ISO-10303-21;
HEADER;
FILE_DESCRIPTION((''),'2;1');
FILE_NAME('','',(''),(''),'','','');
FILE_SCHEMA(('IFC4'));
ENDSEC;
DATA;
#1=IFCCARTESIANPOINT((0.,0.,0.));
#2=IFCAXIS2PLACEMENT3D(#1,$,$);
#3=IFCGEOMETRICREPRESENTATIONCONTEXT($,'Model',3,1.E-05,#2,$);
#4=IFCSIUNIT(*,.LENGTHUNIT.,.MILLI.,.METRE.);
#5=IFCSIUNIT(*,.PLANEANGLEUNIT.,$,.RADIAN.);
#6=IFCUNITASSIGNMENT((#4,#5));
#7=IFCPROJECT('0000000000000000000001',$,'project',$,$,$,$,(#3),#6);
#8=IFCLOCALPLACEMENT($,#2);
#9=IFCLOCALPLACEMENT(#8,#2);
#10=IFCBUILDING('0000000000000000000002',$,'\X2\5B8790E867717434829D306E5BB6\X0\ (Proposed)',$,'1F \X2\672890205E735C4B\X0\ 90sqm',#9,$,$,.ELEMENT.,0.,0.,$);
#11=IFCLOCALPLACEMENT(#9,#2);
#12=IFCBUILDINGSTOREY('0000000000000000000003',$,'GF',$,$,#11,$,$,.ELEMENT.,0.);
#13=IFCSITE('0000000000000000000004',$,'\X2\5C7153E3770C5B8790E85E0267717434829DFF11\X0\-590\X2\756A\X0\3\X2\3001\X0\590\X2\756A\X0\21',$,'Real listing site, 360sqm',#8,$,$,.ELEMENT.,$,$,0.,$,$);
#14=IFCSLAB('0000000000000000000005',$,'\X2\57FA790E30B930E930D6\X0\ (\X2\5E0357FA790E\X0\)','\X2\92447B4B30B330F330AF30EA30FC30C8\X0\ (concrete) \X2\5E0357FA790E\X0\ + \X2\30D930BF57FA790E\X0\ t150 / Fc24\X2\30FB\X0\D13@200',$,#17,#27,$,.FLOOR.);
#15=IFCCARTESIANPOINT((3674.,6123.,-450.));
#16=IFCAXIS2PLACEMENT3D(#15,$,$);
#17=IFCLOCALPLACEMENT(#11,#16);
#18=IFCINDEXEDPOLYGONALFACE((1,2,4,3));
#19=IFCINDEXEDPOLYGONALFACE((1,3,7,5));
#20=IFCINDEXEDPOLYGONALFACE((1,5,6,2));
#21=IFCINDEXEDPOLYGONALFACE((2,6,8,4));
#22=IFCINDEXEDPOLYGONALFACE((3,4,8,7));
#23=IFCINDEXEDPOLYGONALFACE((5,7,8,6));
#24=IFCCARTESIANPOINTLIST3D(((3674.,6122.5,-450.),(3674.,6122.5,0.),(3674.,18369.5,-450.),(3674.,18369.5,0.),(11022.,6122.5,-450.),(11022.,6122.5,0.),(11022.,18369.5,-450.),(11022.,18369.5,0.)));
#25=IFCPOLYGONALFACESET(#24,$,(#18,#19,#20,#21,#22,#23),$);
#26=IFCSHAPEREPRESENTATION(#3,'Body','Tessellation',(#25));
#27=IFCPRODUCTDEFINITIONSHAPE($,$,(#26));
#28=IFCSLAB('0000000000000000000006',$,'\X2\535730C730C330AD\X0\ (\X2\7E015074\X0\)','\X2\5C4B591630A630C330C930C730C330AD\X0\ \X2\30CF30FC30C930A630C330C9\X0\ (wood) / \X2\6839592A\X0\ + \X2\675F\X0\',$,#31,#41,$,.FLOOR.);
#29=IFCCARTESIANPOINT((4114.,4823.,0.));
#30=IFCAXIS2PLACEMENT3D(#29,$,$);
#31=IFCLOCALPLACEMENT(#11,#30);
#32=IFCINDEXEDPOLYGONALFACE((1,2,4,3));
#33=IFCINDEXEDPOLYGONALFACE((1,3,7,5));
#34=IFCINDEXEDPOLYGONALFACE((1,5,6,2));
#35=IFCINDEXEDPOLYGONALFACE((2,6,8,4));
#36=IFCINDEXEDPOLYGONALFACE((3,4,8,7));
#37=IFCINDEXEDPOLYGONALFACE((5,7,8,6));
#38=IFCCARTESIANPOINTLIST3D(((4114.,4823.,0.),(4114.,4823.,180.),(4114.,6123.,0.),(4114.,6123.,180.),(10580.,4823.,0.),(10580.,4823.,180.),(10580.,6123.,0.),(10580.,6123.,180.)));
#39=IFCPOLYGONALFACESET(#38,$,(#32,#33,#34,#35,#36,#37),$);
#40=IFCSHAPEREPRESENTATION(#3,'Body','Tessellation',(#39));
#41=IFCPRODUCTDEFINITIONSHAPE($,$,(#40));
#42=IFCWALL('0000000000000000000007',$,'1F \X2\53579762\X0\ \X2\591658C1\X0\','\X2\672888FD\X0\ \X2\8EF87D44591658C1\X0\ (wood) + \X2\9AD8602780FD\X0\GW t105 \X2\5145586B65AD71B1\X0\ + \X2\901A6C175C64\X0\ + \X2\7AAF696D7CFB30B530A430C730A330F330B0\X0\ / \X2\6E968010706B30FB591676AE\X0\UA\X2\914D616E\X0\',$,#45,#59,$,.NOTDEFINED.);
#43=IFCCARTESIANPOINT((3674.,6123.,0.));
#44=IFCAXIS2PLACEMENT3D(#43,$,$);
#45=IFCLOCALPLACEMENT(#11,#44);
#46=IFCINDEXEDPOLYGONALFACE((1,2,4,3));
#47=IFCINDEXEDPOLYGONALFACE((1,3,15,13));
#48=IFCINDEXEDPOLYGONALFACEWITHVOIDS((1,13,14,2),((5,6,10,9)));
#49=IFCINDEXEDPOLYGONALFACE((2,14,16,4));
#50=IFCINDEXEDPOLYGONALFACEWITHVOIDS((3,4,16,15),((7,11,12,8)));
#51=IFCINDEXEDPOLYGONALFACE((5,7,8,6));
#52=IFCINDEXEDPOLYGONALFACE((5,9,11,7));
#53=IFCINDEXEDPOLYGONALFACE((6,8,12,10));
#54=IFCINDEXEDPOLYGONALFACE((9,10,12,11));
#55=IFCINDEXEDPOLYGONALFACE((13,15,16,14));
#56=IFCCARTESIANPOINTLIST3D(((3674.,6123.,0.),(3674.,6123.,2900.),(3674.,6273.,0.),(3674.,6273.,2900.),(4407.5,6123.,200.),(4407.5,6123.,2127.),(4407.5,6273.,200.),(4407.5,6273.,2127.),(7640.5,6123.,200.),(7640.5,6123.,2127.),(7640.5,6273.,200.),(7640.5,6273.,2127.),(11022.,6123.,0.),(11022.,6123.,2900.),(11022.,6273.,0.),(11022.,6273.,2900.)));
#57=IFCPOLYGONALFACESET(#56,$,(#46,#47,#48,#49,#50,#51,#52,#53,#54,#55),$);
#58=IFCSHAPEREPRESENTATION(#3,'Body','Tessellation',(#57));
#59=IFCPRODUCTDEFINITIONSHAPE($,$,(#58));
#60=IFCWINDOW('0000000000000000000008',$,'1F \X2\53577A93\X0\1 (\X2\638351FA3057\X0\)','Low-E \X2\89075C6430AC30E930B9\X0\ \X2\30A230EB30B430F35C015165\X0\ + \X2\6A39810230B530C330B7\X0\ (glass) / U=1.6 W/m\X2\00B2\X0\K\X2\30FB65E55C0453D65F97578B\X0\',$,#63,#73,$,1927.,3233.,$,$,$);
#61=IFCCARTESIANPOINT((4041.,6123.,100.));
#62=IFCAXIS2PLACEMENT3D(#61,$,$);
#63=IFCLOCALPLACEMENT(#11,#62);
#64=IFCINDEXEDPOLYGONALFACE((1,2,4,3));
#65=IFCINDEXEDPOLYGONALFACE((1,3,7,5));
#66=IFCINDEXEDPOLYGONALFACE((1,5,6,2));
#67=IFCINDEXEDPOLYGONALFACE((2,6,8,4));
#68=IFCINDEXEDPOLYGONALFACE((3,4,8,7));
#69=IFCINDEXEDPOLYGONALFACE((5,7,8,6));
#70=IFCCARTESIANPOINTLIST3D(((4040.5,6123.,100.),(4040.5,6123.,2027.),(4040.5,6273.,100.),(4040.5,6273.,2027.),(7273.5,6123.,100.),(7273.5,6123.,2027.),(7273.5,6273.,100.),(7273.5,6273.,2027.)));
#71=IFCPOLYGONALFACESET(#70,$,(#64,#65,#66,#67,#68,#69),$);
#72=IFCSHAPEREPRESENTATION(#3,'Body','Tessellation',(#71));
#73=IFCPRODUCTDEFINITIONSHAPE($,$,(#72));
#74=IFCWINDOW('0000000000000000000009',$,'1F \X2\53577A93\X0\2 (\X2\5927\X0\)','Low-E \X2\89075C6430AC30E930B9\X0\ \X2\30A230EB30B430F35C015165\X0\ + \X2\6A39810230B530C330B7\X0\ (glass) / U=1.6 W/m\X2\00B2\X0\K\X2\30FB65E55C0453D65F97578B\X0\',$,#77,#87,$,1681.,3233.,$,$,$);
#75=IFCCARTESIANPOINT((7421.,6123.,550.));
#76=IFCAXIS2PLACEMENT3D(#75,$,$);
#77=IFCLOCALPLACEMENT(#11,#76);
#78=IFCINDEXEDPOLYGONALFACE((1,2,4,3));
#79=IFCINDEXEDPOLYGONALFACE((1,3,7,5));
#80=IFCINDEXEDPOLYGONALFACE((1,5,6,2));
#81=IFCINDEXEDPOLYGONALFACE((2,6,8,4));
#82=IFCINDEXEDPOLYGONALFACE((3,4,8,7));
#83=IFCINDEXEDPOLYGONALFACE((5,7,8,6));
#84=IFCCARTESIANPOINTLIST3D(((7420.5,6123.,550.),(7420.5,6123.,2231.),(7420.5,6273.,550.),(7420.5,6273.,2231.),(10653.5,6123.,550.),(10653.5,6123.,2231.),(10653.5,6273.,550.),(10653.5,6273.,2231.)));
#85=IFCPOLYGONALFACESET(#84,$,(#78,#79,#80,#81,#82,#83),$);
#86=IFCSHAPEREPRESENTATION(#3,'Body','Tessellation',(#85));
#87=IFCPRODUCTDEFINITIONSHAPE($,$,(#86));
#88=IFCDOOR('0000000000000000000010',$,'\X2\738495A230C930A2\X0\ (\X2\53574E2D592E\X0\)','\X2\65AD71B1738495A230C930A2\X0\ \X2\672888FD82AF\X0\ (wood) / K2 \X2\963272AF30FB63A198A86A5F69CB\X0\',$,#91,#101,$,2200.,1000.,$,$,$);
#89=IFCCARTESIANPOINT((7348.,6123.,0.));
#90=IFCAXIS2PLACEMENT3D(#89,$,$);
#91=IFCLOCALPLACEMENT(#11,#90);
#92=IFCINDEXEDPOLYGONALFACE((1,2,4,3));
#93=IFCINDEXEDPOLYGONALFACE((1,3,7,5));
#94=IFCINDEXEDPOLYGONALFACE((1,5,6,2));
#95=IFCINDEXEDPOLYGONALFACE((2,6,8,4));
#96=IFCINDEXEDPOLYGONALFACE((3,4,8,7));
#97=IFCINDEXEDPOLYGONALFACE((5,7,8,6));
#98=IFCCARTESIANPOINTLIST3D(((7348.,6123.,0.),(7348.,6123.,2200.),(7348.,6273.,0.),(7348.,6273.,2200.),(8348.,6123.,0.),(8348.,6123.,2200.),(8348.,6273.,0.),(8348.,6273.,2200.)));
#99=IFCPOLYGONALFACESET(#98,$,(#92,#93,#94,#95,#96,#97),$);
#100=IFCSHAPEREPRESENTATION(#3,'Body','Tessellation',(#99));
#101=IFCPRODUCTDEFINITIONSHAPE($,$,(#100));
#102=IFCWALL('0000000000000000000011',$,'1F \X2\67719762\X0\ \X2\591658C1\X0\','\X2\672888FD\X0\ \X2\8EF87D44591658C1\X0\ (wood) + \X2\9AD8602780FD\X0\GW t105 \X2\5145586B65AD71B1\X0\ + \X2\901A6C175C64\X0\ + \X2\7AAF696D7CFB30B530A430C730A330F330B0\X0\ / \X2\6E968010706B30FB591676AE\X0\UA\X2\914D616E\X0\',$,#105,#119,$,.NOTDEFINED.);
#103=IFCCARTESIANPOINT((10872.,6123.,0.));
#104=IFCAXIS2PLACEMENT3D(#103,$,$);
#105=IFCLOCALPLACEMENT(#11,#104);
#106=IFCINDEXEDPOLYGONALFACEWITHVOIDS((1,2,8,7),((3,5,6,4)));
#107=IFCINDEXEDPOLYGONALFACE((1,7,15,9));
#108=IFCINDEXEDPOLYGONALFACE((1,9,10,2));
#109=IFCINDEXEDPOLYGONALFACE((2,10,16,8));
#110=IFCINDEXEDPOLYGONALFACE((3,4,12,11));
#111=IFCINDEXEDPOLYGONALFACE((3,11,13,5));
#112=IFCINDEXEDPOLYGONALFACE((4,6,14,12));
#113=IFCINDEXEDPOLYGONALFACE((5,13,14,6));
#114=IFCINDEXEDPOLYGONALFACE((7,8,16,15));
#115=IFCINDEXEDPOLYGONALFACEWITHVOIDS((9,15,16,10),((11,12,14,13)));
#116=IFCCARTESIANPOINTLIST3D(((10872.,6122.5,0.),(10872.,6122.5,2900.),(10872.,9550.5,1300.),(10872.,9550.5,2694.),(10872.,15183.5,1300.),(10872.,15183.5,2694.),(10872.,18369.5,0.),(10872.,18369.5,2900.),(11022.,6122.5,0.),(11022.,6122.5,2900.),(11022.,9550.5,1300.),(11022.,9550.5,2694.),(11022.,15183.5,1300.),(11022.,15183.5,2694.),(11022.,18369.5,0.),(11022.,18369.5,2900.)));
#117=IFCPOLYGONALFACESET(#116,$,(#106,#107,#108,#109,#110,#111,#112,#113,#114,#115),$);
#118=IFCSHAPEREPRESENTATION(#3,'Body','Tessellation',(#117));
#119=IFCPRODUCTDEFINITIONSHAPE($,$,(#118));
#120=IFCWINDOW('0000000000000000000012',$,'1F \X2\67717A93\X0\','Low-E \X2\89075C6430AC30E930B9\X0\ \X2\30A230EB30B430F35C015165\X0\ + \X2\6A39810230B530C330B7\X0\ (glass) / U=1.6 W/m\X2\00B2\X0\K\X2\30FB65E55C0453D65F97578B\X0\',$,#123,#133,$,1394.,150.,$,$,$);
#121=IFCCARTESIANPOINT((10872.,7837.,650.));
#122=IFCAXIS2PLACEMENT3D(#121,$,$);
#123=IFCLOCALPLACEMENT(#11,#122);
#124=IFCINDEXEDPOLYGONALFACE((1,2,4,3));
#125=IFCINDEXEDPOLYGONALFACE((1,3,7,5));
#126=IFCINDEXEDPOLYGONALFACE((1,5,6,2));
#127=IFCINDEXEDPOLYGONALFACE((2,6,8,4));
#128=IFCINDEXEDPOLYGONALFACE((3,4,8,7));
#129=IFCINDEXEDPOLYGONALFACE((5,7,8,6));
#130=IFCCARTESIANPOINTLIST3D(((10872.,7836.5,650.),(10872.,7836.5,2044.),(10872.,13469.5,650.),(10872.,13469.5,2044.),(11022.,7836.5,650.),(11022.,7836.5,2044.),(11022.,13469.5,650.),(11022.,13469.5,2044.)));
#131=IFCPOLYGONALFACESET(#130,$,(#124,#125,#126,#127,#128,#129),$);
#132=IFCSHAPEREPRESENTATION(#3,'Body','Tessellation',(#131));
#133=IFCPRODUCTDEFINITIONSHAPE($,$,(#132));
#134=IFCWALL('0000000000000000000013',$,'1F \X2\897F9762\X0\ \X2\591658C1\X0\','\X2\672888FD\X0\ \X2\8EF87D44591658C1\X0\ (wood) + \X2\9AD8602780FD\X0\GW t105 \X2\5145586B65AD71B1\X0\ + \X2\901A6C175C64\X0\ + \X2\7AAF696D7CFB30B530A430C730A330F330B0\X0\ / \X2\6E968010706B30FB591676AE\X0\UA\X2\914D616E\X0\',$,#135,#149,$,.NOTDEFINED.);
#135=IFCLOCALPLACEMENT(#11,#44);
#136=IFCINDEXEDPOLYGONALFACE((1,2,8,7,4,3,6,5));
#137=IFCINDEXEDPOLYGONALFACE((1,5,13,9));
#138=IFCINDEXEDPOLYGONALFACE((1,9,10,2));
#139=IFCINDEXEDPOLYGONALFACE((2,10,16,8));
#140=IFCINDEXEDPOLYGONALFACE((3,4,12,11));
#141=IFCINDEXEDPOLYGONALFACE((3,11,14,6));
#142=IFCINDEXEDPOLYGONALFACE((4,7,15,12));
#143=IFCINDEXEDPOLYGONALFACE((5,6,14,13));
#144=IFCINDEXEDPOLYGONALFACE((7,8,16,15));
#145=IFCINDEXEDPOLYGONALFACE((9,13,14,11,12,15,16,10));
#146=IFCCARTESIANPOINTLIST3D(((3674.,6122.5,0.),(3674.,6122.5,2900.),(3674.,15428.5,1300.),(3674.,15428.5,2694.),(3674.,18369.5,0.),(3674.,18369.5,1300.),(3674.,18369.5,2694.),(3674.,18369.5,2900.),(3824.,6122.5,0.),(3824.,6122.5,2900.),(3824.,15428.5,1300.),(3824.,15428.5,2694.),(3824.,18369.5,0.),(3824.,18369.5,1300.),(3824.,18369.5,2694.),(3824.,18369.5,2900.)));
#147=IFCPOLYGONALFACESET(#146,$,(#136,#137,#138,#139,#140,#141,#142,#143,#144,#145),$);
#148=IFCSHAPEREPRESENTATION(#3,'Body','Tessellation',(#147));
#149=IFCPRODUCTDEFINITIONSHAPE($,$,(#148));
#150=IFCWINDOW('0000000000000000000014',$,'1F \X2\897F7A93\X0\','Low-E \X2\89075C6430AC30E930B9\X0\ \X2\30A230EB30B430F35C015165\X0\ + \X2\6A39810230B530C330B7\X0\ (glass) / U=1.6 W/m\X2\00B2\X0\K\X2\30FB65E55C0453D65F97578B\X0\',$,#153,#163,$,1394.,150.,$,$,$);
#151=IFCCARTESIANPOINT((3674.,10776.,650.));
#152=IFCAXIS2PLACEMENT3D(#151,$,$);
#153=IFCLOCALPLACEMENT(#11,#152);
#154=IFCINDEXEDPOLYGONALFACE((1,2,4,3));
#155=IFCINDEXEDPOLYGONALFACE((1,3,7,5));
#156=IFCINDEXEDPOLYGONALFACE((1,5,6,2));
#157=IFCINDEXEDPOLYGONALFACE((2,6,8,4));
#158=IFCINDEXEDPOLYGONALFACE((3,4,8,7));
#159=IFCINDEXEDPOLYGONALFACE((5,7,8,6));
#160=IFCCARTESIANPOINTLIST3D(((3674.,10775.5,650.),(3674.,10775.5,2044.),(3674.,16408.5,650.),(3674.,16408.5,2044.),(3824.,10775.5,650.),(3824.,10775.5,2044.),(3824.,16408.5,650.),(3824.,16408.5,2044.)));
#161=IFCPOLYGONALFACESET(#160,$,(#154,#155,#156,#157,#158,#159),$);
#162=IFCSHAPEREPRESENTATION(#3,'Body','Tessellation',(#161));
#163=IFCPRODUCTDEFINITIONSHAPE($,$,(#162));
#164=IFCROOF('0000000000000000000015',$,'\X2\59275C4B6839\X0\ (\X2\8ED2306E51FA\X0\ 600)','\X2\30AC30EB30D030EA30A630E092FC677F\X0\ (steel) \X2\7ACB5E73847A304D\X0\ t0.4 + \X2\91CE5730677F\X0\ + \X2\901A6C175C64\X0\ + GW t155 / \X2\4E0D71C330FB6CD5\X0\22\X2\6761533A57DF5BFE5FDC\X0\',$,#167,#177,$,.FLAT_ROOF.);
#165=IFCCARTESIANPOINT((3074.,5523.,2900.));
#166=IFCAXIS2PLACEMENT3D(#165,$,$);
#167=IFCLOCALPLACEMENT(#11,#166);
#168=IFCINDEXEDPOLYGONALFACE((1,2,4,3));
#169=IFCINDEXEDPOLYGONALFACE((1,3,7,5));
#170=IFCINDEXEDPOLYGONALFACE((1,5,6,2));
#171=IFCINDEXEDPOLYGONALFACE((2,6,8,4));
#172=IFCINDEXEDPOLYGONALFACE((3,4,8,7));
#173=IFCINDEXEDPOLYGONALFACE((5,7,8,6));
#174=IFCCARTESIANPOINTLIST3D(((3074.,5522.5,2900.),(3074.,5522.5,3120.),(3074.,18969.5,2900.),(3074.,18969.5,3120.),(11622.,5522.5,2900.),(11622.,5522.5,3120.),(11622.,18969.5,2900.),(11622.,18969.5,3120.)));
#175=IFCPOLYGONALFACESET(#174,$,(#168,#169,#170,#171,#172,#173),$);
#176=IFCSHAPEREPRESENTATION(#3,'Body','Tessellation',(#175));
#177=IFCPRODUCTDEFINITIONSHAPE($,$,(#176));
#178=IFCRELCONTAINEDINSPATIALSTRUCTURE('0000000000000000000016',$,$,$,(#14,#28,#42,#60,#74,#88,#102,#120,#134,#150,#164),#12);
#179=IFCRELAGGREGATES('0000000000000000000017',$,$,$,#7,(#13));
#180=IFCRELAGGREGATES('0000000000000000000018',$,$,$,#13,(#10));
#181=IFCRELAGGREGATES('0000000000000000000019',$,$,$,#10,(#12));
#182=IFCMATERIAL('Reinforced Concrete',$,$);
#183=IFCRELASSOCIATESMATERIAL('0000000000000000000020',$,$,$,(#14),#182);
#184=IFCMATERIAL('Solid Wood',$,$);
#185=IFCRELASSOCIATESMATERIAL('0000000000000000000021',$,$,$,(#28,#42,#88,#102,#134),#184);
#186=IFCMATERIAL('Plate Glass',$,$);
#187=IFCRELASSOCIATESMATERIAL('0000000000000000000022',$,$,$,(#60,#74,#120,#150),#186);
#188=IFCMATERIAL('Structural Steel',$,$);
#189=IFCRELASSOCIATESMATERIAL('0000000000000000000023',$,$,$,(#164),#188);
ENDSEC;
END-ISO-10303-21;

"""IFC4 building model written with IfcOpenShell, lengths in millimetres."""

from ifc_helpers import new_model, si_unit, frame, frame_2d, origin, place, context, project, spatial, rectangle, extrude, material, element, fill, save


model = new_model("IFC4")

# Units and contexts
model_context = context("Model", 3, precision=1e-05, world=origin())
ifc_project = project(units=[si_unit("LENGTHUNIT", "METRE", prefix="MILLI"), si_unit("PLANEANGLEUNIT", "RADIAN")], contexts=[model_context])

# Site, building, storey
site_placement = place(None, origin())
site = spatial("IfcSite", under=ifc_project, at=site_placement, Name="山口県宇部市東琴芝１-590番3、590番21", ObjectType="Real listing site, 360sqm", CompositionType="ELEMENT", RefElevation=0.0)
building_placement = place(site_placement, origin())
building = spatial("IfcBuilding", under=site, at=building_placement, Name="宇部東琴芝の家 (Proposed)", ObjectType="1F 木造平屋 90sqm", CompositionType="ELEMENT", ElevationOfRefHeight=0.0, ElevationOfTerrain=0.0)
storey_placement = place(building_placement, origin())
storey = spatial("IfcBuildingStorey", under=building, at=storey_placement, Name="GF", CompositionType="ELEMENT", Elevation=0.0)

# Slabs
ifc_material_1 = material(Name="Reinforced Concrete")
slab_1_placement = place(storey_placement, frame((3674.0, 6123.0, -450.0)))
element("IfcSlab", 1, at=slab_1_placement, inside=storey, material=ifc_material_1, Name="基礎スラブ (布基礎)", Description="鉄筋コンクリート (concrete) 布基礎 + ベタ基礎 t150 / Fc24・D13@200", PredefinedType="FLOOR", context=model_context, shape_type="SweptSolid", body=[
    extrude(rectangle(XDim=7348.0, YDim=12247.0, at=frame_2d((3674.0, 6123.0))), frame((3674.0, 6123.0, -450.0)), (0.0, 0.0, 1.0), 450.0),
])
ifc_material_2 = material(Name="Solid Wood")
slab_2_placement = place(storey_placement, frame((4114.0, 4823.0, 0.0)))
element("IfcSlab", 2, at=slab_2_placement, inside=storey, material=ifc_material_2, Name="南デッキ (縁側)", Description="屋外ウッドデッキ ハードウッド (wood) / 根太 + 束", PredefinedType="FLOOR", context=model_context, shape_type="SweptSolid", body=[
    extrude(rectangle(XDim=6466.0, YDim=1300.0, at=frame_2d((3233.0, 650.0))), frame((4114.0, 4823.0, 0.0)), (0.0, 0.0, 1.0), 180.0),
])

# Wall, openings, windows, door
wall_1_placement = place(storey_placement, frame((3674.0, 6123.0, 0.0)))
wall_1 = element("IfcWall", 3, at=wall_1_placement, inside=storey, material=ifc_material_2, Name="1F 南面 外壁", Description="木製 軸組外壁 (wood) + 高性能GW t105 充填断熱 + 通気層 + 窯業系サイディング / 準耐火・外皮UA配慮", PredefinedType="NOTDEFINED", context=model_context, shape_type="SweptSolid", body=[
    extrude(rectangle(XDim=7348.0, YDim=150.0, at=frame_2d((3674.0, 75.0))), frame((3674.0, 6123.0, 0.0)), (0.0, 0.0, 1.0), 2900.0),
])
opening_1_placement = place(storey_placement, frame((4041.0, 6123.0, 100.0)))
opening_1 = element("IfcOpeningElement", 4, at=opening_1_placement, cuts=wall_1, PredefinedType="NOTDEFINED", context=model_context, shape_type="SweptSolid", body=[
    extrude(rectangle(XDim=3233.0, YDim=150.0, at=frame_2d((1616.0, 75.0))), frame((4041.0, 6123.0, 100.0)), (0.0, 0.0, 1.0), 1927.0),
])
opening_2_placement = place(storey_placement, frame((7421.0, 6123.0, 550.0)))
opening_2 = element("IfcOpeningElement", 5, at=opening_2_placement, cuts=wall_1, PredefinedType="NOTDEFINED", context=model_context, shape_type="SweptSolid", body=[
    extrude(rectangle(XDim=3233.0, YDim=150.0, at=frame_2d((1616.0, 75.0))), frame((7421.0, 6123.0, 550.0)), (0.0, 0.0, 1.0), 1681.0),
])
opening_3_placement = place(storey_placement, frame((7348.0, 6123.0, 0.0)))
opening_3 = element("IfcOpeningElement", 6, at=opening_3_placement, cuts=wall_1, PredefinedType="NOTDEFINED", context=model_context, shape_type="SweptSolid", body=[
    extrude(rectangle(XDim=1000.0, YDim=150.0, at=frame_2d((500.0, 75.0))), frame((7348.0, 6123.0, 0.0)), (0.0, 0.0, 1.0), 2200.0),
])
ifc_material_3 = material(Name="Plate Glass")
window_1_placement = place(storey_placement, frame((4041.0, 6123.0, 100.0)))
window_1 = element("IfcWindow", 7, at=window_1_placement, inside=storey, material=ifc_material_3, Name="1F 南窓1 (掃出し)", Description="Low-E 複層ガラス アルゴン封入 + 樹脂サッシ (glass) / U=1.6 W/m²K・日射取得型", OverallHeight=1927.0, OverallWidth=3233.0, context=model_context, shape_type="SweptSolid", body=[
    extrude(rectangle(XDim=3233.0, YDim=150.0, at=frame_2d((1616.0, 75.0))), frame((4041.0, 6123.0, 100.0)), (0.0, 0.0, 1.0), 1927.0),
])
fill(opening_1, window_1)
window_2_placement = place(storey_placement, frame((7421.0, 6123.0, 550.0)))
window_2 = element("IfcWindow", 8, at=window_2_placement, inside=storey, material=ifc_material_3, Name="1F 南窓2 (大)", Description="Low-E 複層ガラス アルゴン封入 + 樹脂サッシ (glass) / U=1.6 W/m²K・日射取得型", OverallHeight=1681.0, OverallWidth=3233.0, context=model_context, shape_type="SweptSolid", body=[
    extrude(rectangle(XDim=3233.0, YDim=150.0, at=frame_2d((1616.0, 75.0))), frame((7421.0, 6123.0, 550.0)), (0.0, 0.0, 1.0), 1681.0),
])
fill(opening_2, window_2)
door_placement = place(storey_placement, frame((7348.0, 6123.0, 0.0)))
door = element("IfcDoor", 9, at=door_placement, inside=storey, material=ifc_material_2, Name="玄関ドア (南中央)", Description="断熱玄関ドア 木製芯 (wood) / K2 防犯・採風機構", OverallHeight=2200.0, OverallWidth=1000.0, context=model_context, shape_type="SweptSolid", body=[
    extrude(rectangle(XDim=1000.0, YDim=150.0, at=frame_2d((500.0, 75.0))), frame((7348.0, 6123.0, 0.0)), (0.0, 0.0, 1.0), 2200.0),
])
fill(opening_3, door)

# Walls, openings, windows
wall_2_placement = place(storey_placement, frame((10872.0, 6123.0, 0.0)))
wall_2 = element("IfcWall", 10, at=wall_2_placement, inside=storey, material=ifc_material_2, Name="1F 東面 外壁", Description="木製 軸組外壁 (wood) + 高性能GW t105 充填断熱 + 通気層 + 窯業系サイディング / 準耐火・外皮UA配慮", PredefinedType="NOTDEFINED", context=model_context, shape_type="SweptSolid", body=[
    extrude(rectangle(XDim=150.0, YDim=12247.0, at=frame_2d((75.0, 6123.0))), frame((10872.0, 6123.0, 0.0)), (0.0, 0.0, 1.0), 2900.0),
])
opening_4_placement = place(storey_placement, frame((10872.0, 7837.0, 650.0)))
opening_4 = element("IfcOpeningElement", 11, at=opening_4_placement, cuts=wall_2, PredefinedType="NOTDEFINED", context=model_context, shape_type="SweptSolid", body=[
    extrude(rectangle(XDim=150.0, YDim=5633.0, at=frame_2d((75.0, 2816.0))), frame((10872.0, 7837.0, 650.0)), (0.0, 0.0, 1.0), 1394.0),
])
window_3_placement = place(storey_placement, frame((10872.0, 7837.0, 650.0)))
window_3 = element("IfcWindow", 12, at=window_3_placement, inside=storey, material=ifc_material_3, Name="1F 東窓", Description="Low-E 複層ガラス アルゴン封入 + 樹脂サッシ (glass) / U=1.6 W/m²K・日射取得型", OverallHeight=1394.0, OverallWidth=150.0, context=model_context, shape_type="SweptSolid", body=[
    extrude(rectangle(XDim=150.0, YDim=5633.0, at=frame_2d((75.0, 2816.0))), frame((10872.0, 7837.0, 650.0)), (0.0, 0.0, 1.0), 1394.0),
])
fill(opening_4, window_3)
wall_3_placement = place(storey_placement, frame((3674.0, 6123.0, 0.0)))
wall_3 = element("IfcWall", 13, at=wall_3_placement, inside=storey, material=ifc_material_2, Name="1F 西面 外壁", Description="木製 軸組外壁 (wood) + 高性能GW t105 充填断熱 + 通気層 + 窯業系サイディング / 準耐火・外皮UA配慮", PredefinedType="NOTDEFINED", context=model_context, shape_type="SweptSolid", body=[
    extrude(rectangle(XDim=150.0, YDim=12247.0, at=frame_2d((75.0, 6123.0))), frame((3674.0, 6123.0, 0.0)), (0.0, 0.0, 1.0), 2900.0),
])
opening_5_placement = place(storey_placement, frame((3674.0, 10776.0, 650.0)))
opening_5 = element("IfcOpeningElement", 14, at=opening_5_placement, cuts=wall_3, PredefinedType="NOTDEFINED", context=model_context, shape_type="SweptSolid", body=[
    extrude(rectangle(XDim=150.0, YDim=5633.0, at=frame_2d((75.0, 2816.0))), frame((3674.0, 10776.0, 650.0)), (0.0, 0.0, 1.0), 1394.0),
])
window_4_placement = place(storey_placement, frame((3674.0, 10776.0, 650.0)))
window_4 = element("IfcWindow", 15, at=window_4_placement, inside=storey, material=ifc_material_3, Name="1F 西窓", Description="Low-E 複層ガラス アルゴン封入 + 樹脂サッシ (glass) / U=1.6 W/m²K・日射取得型", OverallHeight=1394.0, OverallWidth=150.0, context=model_context, shape_type="SweptSolid", body=[
    extrude(rectangle(XDim=150.0, YDim=5633.0, at=frame_2d((75.0, 2816.0))), frame((3674.0, 10776.0, 650.0)), (0.0, 0.0, 1.0), 1394.0),
])
fill(opening_5, window_4)

# Roof
ifc_material_4 = material(Name="Structural Steel")
roof_placement = place(storey_placement, frame((3074.0, 5523.0, 2900.0)))
element("IfcRoof", 16, at=roof_placement, inside=storey, material=ifc_material_4, Name="大屋根 (軒の出 600)", Description="ガルバリウム鋼板 (steel) 立平葺き t0.4 + 野地板 + 通気層 + GW t155 / 不燃・法22条区域対応", PredefinedType="FLAT_ROOF", context=model_context, shape_type="SweptSolid", body=[
    extrude(rectangle(XDim=8548.0, YDim=13447.0, at=frame_2d((4274.0, 6723.0))), frame((3074.0, 5523.0, 2900.0)), (0.0, 0.0, 1.0), 220.0),
])

save(model, "model.ifc")
